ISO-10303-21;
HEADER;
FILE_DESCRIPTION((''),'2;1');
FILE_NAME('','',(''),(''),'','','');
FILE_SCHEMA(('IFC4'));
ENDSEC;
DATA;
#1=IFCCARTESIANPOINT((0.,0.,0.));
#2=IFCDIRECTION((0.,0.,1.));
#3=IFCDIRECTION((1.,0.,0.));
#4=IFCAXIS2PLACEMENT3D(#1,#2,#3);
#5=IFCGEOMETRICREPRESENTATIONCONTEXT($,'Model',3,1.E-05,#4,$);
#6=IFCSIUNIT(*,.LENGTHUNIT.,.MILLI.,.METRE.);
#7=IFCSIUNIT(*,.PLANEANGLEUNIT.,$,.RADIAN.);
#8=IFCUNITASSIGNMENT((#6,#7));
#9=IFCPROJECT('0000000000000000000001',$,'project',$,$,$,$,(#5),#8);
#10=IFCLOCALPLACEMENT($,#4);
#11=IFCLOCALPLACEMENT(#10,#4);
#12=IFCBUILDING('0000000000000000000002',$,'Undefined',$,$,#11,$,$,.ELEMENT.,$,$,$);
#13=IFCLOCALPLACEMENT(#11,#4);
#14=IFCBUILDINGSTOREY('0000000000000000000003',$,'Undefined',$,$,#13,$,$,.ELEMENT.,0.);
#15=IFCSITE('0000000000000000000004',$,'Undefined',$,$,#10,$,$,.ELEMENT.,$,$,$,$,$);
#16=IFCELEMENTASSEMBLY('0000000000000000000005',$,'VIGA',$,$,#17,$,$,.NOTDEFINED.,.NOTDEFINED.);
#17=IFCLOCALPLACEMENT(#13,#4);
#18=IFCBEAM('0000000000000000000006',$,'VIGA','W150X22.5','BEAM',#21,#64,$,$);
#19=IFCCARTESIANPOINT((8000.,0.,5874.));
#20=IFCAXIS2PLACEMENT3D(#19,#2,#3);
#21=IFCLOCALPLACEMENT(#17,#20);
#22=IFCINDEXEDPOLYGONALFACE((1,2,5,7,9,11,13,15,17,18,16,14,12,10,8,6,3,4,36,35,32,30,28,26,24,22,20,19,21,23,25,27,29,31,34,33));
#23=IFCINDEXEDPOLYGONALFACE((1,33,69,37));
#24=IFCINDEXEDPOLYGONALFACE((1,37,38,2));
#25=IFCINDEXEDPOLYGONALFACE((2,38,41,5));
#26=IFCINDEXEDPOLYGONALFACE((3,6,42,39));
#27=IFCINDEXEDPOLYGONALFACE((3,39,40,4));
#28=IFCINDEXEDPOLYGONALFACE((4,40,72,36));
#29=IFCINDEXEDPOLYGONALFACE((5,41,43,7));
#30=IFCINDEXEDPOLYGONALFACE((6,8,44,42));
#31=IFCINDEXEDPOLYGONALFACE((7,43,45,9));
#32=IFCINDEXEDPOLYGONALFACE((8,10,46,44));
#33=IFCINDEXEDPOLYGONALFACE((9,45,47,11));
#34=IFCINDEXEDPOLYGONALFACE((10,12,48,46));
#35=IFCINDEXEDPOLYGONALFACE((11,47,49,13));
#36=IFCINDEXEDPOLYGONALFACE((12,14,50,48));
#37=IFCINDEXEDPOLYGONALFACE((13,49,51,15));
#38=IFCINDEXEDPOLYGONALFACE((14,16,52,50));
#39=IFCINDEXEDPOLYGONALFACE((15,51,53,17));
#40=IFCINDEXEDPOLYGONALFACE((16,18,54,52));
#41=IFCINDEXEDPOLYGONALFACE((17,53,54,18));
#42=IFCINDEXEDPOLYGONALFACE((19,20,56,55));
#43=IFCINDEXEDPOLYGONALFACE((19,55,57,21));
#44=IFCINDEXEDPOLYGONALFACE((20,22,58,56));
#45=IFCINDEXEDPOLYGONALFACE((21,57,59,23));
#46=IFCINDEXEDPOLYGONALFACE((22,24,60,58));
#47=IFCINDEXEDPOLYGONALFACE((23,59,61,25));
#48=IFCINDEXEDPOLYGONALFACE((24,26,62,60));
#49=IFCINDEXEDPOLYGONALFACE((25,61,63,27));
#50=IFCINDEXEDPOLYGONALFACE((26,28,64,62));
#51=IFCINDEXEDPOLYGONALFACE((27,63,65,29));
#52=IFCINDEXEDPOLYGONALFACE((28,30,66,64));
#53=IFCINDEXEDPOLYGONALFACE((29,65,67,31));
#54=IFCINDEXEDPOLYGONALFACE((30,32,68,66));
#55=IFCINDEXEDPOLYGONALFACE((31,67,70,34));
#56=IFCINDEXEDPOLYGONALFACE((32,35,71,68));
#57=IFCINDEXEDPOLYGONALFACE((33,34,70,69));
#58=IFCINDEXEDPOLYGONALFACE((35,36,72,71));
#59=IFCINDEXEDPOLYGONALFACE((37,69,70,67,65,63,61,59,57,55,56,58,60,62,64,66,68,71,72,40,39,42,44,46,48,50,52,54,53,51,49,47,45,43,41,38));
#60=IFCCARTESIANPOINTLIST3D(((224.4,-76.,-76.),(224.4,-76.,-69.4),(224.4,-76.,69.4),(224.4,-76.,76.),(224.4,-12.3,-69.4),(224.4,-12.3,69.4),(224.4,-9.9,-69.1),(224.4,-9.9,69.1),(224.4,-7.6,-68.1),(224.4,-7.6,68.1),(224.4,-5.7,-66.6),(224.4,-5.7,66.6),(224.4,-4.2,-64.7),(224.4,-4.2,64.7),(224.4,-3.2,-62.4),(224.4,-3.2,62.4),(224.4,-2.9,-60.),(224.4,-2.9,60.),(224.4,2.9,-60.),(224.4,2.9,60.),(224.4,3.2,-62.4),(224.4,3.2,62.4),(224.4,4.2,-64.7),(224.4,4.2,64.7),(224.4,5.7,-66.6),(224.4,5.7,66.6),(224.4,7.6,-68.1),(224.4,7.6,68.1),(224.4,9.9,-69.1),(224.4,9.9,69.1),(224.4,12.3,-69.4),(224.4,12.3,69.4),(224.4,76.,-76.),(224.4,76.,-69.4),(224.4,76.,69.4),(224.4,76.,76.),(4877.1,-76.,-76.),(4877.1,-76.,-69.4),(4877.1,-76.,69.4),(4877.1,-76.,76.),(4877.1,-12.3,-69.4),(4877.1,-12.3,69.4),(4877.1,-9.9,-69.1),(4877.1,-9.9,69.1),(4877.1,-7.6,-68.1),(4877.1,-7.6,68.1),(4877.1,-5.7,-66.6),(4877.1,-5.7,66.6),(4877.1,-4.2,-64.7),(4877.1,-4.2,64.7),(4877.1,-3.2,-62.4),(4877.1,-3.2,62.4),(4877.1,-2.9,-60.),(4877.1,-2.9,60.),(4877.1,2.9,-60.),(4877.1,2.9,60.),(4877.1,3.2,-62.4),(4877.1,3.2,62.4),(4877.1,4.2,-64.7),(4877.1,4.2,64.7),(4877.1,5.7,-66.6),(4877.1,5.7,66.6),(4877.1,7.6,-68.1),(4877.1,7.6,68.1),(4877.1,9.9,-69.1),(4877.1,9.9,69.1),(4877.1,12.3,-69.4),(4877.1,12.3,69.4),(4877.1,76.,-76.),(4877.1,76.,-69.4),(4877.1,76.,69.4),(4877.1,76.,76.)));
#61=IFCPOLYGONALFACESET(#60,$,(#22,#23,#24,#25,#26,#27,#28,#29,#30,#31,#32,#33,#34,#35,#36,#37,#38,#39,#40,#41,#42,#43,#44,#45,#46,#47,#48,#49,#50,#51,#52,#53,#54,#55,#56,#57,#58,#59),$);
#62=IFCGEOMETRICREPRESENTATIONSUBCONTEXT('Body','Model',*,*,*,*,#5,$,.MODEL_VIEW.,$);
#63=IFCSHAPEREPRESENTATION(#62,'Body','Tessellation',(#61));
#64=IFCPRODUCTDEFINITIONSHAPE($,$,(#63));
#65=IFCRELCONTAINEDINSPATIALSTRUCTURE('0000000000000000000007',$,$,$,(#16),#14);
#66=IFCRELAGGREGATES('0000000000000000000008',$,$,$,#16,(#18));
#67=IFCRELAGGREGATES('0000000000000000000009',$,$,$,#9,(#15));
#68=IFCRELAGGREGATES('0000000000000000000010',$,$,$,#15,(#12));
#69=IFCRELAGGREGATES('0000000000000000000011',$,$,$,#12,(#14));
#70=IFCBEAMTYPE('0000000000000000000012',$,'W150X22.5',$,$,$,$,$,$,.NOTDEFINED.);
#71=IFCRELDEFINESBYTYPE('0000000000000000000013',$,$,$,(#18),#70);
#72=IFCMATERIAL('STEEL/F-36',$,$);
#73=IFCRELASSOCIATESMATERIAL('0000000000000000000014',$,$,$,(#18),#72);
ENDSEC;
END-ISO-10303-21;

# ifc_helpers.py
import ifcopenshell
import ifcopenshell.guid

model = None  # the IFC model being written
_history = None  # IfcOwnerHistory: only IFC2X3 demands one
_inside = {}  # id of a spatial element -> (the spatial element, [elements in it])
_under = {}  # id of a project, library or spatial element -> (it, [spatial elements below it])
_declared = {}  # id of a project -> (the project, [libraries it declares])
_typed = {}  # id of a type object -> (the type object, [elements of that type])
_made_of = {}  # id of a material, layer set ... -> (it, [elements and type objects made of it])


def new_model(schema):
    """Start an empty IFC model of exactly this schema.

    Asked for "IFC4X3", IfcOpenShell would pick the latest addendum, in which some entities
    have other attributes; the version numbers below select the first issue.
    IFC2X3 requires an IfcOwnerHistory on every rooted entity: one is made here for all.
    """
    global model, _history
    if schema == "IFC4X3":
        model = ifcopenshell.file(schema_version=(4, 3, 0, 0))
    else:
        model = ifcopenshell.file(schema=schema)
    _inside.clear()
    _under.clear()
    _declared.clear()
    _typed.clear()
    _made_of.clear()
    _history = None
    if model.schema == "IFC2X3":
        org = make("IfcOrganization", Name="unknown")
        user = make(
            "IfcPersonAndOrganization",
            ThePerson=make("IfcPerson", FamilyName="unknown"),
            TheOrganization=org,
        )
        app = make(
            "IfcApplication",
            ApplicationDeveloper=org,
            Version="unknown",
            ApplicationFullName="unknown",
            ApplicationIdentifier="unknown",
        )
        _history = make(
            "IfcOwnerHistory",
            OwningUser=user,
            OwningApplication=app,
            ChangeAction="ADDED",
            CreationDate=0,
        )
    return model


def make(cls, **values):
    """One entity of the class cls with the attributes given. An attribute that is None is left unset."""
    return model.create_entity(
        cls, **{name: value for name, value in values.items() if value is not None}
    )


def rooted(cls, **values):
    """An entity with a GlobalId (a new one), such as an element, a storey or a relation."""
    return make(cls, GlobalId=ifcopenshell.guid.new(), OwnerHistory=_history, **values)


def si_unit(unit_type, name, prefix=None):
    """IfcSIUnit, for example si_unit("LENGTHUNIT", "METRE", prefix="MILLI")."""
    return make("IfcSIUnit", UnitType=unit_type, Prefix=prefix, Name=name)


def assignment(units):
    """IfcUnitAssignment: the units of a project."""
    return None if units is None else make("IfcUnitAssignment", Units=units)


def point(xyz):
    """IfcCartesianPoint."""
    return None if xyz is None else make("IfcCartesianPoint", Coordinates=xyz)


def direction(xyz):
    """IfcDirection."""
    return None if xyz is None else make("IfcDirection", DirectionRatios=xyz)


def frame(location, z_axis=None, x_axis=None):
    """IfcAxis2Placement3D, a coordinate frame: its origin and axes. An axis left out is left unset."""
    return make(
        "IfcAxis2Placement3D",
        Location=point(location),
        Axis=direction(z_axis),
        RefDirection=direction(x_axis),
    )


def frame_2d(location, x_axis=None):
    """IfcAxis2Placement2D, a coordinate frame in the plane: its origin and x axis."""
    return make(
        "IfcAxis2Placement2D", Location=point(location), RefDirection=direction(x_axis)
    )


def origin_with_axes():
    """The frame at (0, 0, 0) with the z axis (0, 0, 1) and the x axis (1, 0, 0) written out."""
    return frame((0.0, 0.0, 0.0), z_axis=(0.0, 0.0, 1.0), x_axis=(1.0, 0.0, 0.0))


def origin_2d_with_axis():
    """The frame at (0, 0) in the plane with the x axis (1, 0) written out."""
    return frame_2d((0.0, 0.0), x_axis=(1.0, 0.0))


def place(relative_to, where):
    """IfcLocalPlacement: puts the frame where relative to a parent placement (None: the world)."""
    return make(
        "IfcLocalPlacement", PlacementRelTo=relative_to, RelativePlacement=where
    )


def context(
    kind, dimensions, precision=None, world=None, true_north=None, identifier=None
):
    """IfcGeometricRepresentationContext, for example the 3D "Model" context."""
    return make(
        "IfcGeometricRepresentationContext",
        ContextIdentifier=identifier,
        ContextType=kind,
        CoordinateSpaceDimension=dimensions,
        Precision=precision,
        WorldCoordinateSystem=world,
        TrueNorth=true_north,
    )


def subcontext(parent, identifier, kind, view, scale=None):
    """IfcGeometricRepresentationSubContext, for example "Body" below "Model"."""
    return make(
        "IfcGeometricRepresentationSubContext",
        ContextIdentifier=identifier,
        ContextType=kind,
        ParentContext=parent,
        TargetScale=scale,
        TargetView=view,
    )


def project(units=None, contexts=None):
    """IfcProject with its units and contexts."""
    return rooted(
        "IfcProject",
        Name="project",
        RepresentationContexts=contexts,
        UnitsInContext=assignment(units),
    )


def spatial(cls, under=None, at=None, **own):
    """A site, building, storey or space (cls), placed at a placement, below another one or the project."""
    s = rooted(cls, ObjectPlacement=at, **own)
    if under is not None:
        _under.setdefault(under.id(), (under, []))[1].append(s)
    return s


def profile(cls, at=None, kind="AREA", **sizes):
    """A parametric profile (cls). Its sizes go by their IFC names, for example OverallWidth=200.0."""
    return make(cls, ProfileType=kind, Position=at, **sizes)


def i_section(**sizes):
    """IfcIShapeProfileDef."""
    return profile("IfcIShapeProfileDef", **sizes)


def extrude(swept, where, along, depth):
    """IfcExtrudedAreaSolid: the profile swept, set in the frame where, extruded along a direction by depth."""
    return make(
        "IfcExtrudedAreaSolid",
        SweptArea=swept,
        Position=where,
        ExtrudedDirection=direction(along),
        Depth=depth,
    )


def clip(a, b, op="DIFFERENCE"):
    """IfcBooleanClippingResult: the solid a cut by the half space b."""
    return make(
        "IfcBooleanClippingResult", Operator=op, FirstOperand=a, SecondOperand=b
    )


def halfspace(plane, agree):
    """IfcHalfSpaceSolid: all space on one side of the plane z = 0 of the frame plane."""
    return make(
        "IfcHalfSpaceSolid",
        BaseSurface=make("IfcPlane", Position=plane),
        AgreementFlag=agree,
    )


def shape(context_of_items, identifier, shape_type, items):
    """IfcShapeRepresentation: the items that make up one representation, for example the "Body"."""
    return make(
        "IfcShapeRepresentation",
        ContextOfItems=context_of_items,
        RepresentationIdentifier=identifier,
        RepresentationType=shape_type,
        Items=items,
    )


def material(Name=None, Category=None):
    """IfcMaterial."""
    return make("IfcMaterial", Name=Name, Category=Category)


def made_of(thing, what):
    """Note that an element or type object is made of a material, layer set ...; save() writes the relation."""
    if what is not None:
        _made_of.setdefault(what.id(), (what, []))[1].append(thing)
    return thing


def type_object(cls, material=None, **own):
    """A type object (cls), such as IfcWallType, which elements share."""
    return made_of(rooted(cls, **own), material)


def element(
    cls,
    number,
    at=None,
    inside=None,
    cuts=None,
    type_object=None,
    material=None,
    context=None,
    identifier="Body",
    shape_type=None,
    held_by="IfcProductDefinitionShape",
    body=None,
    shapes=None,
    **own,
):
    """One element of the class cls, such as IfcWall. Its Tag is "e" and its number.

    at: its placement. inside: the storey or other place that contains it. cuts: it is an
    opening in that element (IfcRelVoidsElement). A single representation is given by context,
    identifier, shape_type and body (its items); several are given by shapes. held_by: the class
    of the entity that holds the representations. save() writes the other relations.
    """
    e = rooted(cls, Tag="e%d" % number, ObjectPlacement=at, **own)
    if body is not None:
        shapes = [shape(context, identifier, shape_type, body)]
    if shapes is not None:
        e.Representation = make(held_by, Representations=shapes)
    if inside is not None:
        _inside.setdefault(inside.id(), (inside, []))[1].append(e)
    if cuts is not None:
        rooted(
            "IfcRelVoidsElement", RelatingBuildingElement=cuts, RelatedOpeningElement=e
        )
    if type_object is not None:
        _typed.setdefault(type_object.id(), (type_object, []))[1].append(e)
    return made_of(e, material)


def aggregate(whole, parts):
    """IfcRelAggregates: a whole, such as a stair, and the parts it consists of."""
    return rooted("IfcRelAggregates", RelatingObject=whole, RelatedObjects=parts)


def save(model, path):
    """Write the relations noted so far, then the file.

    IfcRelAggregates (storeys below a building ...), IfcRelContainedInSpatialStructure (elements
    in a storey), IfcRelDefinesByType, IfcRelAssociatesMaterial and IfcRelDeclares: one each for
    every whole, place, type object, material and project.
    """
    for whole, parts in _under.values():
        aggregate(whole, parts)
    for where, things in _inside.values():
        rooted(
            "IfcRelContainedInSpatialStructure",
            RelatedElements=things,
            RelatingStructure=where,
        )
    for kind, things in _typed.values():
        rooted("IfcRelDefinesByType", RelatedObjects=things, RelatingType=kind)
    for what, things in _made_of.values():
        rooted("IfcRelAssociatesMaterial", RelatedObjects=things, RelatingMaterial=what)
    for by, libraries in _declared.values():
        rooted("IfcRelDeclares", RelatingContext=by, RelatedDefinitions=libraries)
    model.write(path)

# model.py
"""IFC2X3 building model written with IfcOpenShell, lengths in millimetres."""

from ifc_helpers import new_model, si_unit, frame, origin_with_axes, origin_2d_with_axis, place, context, subcontext, project, spatial, i_section, extrude, clip, halfspace, material, type_object, element, aggregate, save


model = new_model("IFC2X3")

# Units and contexts
model_context = context("Model", 3, precision=1e-05, world=origin_with_axes())
body_context = subcontext(model_context, "Body", "Model", "MODEL_VIEW")
ifc_project = project(units=[si_unit("LENGTHUNIT", "METRE", prefix="MILLI"), si_unit("PLANEANGLEUNIT", "RADIAN")], contexts=[model_context])

# Site, building, storey
site_placement = place(None, origin_with_axes())
site = spatial("IfcSite", under=ifc_project, at=site_placement, Name="Undefined", CompositionType="ELEMENT")
building_placement = place(site_placement, origin_with_axes())
building = spatial("IfcBuilding", under=site, at=building_placement, Name="Undefined", CompositionType="ELEMENT")
storey_placement = place(building_placement, origin_with_axes())
storey = spatial("IfcBuildingStorey", under=building, at=storey_placement, Name="Undefined", CompositionType="ELEMENT", Elevation=0.0)

# Element assembly, beam
assembly_1_placement = place(storey_placement, origin_with_axes())
assembly_1 = element("IfcElementAssembly", 1, at=assembly_1_placement, inside=storey, Name="VIGA", AssemblyPlace="NOTDEFINED", PredefinedType="NOTDEFINED")
ifc_material_1 = material(Name="STEEL/F-36")
beam_type_1 = type_object("IfcBeamType", Name="W150X22.5", PredefinedType="NOTDEFINED")
beam_1_placement = place(assembly_1_placement, frame((8000.0, 0.0, 5874.0), z_axis=(0.0, 0.0, 1.0), x_axis=(1.0, 0.0, 0.0)))
beam_1 = element("IfcBeam", 2, at=beam_1_placement, type_object=beam_type_1, material=ifc_material_1, Name="VIGA", Description="W150X22.5", ObjectType="BEAM", context=body_context, shape_type="Clipping", body=[
    clip(clip(extrude(i_section(OverallWidth=152.0, OverallDepth=152.0, WebThickness=5.8, FlangeThickness=6.6, FilletRadius=9.4, at=origin_2d_with_axis()), frame((5000.0, 0.0, 0.0), z_axis=(-1.0, 0.0, 0.0), x_axis=(0.0, -1.0, 0.0)), (0.0, 0.0, 1.0), 5000.0), halfspace(frame((4877.1, 0.0, 0.0), z_axis=(-1.0, 0.0, 0.0), x_axis=(0.0, 1.0, 0.0)), True)), halfspace(frame((224.4, 0.0, 0.0), z_axis=(-1.0, 0.0, 0.0), x_axis=(0.0, 1.0, 0.0)), False)),
])
aggregate(assembly_1, [beam_1])

save(model, "model.ifc")
